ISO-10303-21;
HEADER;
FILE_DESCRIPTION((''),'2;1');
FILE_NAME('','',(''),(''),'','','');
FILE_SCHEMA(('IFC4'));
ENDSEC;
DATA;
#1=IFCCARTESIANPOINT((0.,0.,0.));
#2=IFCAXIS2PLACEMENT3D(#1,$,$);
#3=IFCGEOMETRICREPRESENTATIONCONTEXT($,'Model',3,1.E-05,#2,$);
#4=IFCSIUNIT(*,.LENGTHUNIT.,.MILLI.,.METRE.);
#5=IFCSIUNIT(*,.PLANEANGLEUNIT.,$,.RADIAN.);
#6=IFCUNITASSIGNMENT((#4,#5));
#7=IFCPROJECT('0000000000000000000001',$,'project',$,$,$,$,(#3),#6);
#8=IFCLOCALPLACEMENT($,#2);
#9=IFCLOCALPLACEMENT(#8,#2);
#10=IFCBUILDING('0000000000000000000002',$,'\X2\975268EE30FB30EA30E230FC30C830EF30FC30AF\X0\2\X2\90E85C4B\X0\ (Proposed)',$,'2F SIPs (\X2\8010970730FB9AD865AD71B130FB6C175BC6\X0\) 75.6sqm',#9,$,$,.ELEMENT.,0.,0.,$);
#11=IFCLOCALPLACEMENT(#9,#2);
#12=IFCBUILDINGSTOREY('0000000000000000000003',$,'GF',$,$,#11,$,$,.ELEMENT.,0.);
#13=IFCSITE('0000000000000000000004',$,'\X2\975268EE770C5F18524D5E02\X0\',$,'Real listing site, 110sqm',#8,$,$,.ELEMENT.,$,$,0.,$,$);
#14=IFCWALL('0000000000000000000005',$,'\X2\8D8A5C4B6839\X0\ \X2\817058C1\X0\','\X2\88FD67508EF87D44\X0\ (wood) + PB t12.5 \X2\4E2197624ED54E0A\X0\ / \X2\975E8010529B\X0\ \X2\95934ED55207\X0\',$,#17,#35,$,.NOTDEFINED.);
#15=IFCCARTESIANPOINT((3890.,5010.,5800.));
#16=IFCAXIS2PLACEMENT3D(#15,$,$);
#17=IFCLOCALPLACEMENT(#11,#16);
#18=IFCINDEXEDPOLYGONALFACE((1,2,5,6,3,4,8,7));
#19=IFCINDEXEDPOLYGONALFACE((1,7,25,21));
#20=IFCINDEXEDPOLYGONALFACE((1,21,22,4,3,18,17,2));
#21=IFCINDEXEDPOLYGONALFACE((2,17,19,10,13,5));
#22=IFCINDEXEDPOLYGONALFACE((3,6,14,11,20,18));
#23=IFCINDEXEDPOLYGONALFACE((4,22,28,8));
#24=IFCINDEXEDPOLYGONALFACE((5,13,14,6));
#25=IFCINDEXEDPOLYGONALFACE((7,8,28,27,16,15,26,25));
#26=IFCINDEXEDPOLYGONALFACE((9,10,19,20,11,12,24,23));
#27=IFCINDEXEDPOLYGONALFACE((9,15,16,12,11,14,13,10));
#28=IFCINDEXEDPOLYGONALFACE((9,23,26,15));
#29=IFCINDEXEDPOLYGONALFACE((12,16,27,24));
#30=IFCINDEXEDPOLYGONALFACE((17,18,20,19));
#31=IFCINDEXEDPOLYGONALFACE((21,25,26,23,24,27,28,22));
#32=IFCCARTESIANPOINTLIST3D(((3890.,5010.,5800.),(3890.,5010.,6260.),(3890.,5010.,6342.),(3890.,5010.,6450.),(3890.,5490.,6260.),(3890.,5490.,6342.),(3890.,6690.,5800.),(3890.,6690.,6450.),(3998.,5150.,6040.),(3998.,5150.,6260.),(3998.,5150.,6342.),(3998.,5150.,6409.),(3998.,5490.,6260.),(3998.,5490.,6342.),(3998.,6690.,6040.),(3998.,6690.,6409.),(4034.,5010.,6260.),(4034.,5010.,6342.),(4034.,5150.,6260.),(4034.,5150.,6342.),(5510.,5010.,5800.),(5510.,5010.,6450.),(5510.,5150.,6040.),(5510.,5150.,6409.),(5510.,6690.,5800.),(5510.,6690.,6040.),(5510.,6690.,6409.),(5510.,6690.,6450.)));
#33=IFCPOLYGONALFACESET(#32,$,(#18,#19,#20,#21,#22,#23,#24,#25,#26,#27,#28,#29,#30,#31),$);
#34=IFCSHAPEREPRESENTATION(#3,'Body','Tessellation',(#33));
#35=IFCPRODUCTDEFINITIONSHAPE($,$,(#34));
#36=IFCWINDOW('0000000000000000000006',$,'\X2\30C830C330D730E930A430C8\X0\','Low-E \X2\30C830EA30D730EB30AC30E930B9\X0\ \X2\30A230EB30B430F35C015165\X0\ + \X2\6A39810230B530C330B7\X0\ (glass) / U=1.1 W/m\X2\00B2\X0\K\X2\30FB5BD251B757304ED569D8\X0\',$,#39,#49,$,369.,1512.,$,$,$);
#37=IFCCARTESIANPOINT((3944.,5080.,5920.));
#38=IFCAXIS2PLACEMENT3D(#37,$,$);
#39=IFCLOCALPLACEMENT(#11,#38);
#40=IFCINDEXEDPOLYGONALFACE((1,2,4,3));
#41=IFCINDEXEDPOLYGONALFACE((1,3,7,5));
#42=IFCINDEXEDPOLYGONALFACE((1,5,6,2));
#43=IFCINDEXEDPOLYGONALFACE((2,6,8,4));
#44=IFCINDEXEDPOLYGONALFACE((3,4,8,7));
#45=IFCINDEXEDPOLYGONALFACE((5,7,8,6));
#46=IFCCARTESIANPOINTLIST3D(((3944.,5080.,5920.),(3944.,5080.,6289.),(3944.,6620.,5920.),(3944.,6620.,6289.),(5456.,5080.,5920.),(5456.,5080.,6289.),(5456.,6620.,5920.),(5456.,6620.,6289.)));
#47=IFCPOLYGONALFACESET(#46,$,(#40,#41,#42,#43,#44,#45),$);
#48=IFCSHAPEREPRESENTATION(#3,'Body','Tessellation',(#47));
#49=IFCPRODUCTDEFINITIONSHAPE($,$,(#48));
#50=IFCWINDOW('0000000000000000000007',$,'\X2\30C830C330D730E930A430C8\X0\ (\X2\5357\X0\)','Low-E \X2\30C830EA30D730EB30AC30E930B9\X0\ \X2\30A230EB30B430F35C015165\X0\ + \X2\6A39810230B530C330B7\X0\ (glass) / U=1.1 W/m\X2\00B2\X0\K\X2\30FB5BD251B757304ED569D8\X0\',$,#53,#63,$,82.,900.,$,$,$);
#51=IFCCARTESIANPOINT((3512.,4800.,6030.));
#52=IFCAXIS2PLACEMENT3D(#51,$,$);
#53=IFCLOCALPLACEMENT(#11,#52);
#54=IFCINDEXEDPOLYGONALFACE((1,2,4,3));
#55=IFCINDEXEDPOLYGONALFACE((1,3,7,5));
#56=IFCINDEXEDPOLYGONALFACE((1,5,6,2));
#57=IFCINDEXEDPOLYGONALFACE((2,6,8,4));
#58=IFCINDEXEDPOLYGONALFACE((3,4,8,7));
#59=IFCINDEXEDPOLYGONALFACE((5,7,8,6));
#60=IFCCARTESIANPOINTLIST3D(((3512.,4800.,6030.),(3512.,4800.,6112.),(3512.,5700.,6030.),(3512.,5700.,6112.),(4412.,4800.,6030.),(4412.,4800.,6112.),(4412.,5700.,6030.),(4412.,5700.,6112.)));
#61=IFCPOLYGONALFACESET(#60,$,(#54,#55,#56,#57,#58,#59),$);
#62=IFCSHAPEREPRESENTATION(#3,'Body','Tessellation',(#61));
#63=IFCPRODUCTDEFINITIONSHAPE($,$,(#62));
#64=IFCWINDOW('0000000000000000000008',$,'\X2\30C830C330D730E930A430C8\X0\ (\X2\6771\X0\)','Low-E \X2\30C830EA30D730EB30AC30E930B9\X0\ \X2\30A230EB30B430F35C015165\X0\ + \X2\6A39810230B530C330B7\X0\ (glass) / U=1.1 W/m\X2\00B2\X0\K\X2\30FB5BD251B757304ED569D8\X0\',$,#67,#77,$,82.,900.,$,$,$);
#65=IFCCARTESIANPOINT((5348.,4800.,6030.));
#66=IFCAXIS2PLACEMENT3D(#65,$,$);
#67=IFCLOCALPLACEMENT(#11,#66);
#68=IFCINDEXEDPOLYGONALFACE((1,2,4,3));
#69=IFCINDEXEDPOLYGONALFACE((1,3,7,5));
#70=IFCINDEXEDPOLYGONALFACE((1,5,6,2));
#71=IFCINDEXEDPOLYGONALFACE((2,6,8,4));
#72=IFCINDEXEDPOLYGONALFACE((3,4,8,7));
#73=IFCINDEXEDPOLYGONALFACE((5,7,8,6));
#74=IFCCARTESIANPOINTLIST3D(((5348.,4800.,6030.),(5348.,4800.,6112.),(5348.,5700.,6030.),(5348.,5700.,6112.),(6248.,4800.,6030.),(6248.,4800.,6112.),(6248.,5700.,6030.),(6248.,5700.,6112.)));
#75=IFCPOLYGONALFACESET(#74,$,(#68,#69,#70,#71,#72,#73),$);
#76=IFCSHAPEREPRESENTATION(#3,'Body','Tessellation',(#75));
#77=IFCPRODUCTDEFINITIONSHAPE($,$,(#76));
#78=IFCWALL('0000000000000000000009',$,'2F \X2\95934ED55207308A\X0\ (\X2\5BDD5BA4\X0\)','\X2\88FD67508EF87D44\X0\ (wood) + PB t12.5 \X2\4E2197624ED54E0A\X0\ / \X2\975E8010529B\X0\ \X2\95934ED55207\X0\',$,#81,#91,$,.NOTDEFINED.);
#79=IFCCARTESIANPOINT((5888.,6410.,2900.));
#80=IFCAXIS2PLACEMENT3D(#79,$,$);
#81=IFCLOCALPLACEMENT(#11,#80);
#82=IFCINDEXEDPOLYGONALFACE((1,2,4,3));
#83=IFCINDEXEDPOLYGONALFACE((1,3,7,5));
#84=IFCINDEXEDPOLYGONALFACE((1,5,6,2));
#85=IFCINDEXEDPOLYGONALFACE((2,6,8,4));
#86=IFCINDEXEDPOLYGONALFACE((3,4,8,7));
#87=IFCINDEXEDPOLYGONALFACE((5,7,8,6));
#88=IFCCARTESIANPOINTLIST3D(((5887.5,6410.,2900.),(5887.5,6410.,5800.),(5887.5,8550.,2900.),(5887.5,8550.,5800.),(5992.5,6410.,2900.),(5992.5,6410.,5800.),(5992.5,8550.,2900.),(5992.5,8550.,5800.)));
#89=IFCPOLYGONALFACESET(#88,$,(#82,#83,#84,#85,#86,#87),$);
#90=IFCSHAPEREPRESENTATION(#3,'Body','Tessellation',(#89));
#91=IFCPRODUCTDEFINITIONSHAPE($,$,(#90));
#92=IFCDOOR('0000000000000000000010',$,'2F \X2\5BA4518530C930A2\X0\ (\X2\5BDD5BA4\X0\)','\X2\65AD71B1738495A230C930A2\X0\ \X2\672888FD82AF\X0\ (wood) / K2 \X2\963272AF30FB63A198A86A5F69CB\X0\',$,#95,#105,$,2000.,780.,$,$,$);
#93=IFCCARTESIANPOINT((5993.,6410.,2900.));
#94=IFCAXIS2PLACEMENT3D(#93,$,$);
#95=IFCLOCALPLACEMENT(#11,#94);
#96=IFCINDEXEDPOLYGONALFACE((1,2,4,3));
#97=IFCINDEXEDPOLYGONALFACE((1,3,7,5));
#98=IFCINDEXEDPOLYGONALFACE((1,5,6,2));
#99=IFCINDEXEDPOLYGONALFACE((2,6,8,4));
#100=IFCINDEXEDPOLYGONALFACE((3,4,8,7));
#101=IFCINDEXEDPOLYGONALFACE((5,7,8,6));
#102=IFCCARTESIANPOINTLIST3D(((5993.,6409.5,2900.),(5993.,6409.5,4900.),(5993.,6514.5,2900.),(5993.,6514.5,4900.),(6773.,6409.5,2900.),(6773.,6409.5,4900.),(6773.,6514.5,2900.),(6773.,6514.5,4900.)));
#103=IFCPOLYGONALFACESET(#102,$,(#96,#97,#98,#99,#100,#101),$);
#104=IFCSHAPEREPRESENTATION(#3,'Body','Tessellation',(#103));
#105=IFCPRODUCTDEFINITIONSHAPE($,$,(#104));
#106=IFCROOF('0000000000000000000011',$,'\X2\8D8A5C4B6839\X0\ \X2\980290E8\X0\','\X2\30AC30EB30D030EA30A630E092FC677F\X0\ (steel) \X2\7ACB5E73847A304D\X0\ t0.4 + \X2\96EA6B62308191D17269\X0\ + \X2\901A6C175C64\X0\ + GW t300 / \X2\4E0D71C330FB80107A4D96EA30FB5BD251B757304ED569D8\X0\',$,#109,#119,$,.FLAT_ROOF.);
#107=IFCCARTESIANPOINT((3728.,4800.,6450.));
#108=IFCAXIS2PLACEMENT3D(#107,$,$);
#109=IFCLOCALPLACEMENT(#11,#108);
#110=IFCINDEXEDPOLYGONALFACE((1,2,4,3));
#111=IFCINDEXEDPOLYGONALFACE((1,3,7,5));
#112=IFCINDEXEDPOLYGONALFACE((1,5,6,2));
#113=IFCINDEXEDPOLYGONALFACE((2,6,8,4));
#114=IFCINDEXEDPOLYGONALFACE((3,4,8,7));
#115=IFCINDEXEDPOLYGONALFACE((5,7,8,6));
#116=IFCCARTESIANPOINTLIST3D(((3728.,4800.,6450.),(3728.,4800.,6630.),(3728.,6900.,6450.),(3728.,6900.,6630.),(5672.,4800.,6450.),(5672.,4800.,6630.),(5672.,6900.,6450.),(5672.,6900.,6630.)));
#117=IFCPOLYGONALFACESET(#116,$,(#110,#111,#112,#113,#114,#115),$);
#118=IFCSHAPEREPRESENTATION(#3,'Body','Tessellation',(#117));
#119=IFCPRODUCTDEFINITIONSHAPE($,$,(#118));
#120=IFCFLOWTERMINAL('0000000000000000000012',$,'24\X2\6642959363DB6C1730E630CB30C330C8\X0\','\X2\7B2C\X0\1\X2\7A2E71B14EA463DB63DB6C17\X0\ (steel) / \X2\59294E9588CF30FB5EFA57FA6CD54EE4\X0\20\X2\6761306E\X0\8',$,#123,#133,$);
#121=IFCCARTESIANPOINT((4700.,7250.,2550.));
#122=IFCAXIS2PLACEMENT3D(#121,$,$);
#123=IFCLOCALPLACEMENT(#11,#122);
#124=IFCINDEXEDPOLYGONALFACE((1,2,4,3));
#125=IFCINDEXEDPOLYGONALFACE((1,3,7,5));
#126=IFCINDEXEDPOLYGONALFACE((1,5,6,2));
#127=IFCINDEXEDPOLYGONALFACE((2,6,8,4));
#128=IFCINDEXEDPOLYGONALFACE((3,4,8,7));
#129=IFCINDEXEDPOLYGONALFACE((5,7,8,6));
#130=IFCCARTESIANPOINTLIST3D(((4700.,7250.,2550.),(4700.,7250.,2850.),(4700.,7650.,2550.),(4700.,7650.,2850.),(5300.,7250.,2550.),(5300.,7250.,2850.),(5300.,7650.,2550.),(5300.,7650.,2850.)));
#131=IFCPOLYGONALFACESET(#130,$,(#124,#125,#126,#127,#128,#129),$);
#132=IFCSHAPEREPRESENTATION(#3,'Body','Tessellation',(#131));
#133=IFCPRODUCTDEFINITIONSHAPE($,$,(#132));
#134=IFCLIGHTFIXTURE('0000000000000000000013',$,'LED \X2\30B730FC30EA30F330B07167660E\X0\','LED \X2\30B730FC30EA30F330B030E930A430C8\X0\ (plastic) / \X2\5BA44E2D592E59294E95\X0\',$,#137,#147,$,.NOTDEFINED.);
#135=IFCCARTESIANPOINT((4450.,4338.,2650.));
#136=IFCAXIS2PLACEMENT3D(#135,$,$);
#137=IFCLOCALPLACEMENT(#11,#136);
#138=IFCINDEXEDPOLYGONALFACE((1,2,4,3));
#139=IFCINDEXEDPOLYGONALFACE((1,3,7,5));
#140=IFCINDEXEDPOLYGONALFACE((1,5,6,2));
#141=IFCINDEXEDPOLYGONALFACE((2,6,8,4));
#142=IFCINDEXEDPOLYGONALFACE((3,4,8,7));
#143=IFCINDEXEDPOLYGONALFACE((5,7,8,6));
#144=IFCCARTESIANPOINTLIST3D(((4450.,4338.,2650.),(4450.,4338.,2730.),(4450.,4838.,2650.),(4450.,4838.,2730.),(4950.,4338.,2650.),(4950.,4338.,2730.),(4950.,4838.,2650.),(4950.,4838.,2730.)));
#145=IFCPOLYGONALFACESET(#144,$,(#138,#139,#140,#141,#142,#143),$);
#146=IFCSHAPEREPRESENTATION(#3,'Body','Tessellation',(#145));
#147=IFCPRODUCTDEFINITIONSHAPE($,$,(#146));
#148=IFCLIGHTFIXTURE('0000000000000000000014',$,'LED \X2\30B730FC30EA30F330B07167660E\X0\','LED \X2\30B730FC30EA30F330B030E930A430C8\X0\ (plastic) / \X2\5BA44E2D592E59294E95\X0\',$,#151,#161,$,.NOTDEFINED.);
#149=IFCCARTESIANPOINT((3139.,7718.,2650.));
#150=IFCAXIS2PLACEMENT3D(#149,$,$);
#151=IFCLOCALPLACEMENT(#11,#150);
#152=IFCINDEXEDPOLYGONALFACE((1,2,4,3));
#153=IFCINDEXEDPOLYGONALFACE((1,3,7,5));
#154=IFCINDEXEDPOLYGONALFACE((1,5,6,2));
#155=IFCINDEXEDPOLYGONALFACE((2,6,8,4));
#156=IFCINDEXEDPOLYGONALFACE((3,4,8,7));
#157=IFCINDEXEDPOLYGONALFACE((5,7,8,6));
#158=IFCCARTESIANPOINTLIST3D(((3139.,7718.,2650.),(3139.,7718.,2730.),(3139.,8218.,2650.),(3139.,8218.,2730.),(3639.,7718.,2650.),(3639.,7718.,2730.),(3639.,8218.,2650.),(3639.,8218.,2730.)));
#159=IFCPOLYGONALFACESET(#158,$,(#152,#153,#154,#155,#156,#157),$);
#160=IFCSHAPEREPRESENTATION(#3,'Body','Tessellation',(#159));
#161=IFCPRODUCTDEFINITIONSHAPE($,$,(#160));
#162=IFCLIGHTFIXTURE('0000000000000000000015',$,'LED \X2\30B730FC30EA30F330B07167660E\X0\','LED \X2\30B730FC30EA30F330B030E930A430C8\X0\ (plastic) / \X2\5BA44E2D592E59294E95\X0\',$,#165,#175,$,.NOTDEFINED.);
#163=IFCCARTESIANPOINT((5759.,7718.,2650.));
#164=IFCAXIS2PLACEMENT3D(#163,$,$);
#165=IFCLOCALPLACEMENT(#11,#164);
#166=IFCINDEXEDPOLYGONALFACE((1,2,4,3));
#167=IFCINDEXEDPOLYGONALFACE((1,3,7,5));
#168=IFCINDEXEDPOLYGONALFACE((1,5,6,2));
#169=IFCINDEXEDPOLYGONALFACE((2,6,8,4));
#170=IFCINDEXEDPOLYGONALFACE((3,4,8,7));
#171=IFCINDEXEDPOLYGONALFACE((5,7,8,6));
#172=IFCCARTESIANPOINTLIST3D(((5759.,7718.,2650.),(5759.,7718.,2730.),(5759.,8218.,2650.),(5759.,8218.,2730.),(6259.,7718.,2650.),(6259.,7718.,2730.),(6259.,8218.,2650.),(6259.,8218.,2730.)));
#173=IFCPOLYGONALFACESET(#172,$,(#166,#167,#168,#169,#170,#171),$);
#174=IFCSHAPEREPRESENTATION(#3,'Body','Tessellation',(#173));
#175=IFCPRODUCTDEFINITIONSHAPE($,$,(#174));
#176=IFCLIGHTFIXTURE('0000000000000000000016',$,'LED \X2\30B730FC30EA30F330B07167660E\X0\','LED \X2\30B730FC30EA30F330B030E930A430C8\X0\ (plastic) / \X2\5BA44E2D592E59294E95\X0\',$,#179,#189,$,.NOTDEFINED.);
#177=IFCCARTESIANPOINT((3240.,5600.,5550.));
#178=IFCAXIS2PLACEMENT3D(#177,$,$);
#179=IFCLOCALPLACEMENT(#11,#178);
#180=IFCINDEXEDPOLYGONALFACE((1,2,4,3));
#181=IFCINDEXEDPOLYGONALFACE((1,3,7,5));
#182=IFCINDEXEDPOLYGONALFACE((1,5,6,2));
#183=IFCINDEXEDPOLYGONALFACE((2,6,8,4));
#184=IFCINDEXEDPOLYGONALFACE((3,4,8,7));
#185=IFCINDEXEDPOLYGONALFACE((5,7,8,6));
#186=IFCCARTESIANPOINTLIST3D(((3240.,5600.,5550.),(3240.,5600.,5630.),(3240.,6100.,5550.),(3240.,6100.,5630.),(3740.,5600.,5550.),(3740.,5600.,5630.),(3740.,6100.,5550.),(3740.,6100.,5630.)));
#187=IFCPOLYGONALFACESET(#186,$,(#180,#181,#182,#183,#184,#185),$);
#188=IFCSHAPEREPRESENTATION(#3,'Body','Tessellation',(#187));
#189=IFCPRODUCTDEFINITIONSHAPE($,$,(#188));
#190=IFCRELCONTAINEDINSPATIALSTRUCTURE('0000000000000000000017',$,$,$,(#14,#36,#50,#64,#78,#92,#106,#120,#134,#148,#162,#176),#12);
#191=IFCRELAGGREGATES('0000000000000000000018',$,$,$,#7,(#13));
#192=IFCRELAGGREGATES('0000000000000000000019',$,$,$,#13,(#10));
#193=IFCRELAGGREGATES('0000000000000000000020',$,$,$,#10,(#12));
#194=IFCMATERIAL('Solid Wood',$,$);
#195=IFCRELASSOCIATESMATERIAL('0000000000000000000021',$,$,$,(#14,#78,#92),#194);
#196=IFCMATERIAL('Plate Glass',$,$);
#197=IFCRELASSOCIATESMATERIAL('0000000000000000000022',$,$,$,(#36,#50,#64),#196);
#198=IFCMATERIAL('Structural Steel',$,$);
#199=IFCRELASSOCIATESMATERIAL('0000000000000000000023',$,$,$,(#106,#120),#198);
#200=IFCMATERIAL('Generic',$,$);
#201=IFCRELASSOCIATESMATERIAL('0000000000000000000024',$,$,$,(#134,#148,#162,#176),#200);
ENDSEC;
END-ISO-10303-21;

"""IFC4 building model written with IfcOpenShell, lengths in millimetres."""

from ifc_helpers import new_model, si_unit, frame, frame_2d, origin, place, context, project, spatial, rectangle, extrude, material, element, fill, save


model = new_model("IFC4")

# Units and contexts
model_context = context("Model", 3, precision=1e-05, world=origin())
ifc_project = project(units=[si_unit("LENGTHUNIT", "METRE", prefix="MILLI"), si_unit("PLANEANGLEUNIT", "RADIAN")], contexts=[model_context])

# Site, building, storey
site_placement = place(None, origin())
site = spatial("IfcSite", under=ifc_project, at=site_placement, Name="青森県弘前市", ObjectType="Real listing site, 110sqm", CompositionType="ELEMENT", RefElevation=0.0)
building_placement = place(site_placement, origin())
building = spatial("IfcBuilding", under=site, at=building_placement, Name="青森・リモートワーク2部屋 (Proposed)", ObjectType="2F SIPs (耐震・高断熱・気密) 75.6sqm", CompositionType="ELEMENT", ElevationOfRefHeight=0.0, ElevationOfTerrain=0.0)
storey_placement = place(building_placement, origin())
storey = spatial("IfcBuildingStorey", under=building, at=storey_placement, Name="GF", CompositionType="ELEMENT", Elevation=0.0)

# Shared definitions
ifc_material_1 = material(Name="Solid Wood")

# Shared definitions
ifc_material_2 = material(Name="Plate Glass")

# Wall, openings, windows
wall_1_placement = place(storey_placement, frame((3890.0, 5010.0, 5800.0)))
wall_1 = element("IfcWall", 1, at=wall_1_placement, inside=storey, material=ifc_material_1, Name="越屋根 腰壁", Description="製材軸組 (wood) + PB t12.5 両面仕上 / 非耐力 間仕切", PredefinedType="NOTDEFINED", context=model_context, shape_type="SweptSolid", body=[
    extrude(rectangle(XDim=1620.0, YDim=1680.0, at=frame_2d((810.0, 840.0))), frame((3890.0, 5010.0, 5800.0)), (0.0, 0.0, 1.0), 650.0),
])
opening_1_placement = place(storey_placement, frame((3944.0, 5080.0, 5920.0)))
opening_1 = element("IfcOpeningElement", 2, at=opening_1_placement, cuts=wall_1, PredefinedType="NOTDEFINED", context=model_context, shape_type="SweptSolid", body=[
    extrude(rectangle(XDim=1512.0, YDim=1540.0, at=frame_2d((756.0, 770.0))), frame((3944.0, 5080.0, 5920.0)), (0.0, 0.0, 1.0), 369.0),
])
opening_2_placement = place(storey_placement, frame((3512.0, 4800.0, 6030.0)))
opening_2 = element("IfcOpeningElement", 3, at=opening_2_placement, cuts=wall_1, PredefinedType="NOTDEFINED", context=model_context, shape_type="SweptSolid", body=[
    extrude(rectangle(XDim=900.0, YDim=900.0, at=frame_2d((450.0, 450.0))), frame((3512.0, 4800.0, 6030.0)), (0.0, 0.0, 1.0), 82.0),
])
opening_3_placement = place(storey_placement, frame((5348.0, 4800.0, 6030.0)))
opening_3 = element("IfcOpeningElement", 4, at=opening_3_placement, cuts=wall_1, PredefinedType="NOTDEFINED", context=model_context, shape_type="SweptSolid", body=[
    extrude(rectangle(XDim=900.0, YDim=900.0, at=frame_2d((450.0, 450.0))), frame((5348.0, 4800.0, 6030.0)), (0.0, 0.0, 1.0), 82.0),
])
window_1_placement = place(storey_placement, frame((3944.0, 5080.0, 5920.0)))
window_1 = element("IfcWindow", 5, at=window_1_placement, inside=storey, material=ifc_material_2, Name="トップライト", Description="Low-E トリプルガラス アルゴン封入 + 樹脂サッシ (glass) / U=1.1 W/m²K・寒冷地仕様", OverallHeight=369.0, OverallWidth=1512.0, context=model_context, shape_type="SweptSolid", body=[
    extrude(rectangle(XDim=1512.0, YDim=1540.0, at=frame_2d((756.0, 770.0))), frame((3944.0, 5080.0, 5920.0)), (0.0, 0.0, 1.0), 369.0),
])
fill(opening_1, window_1)
window_2_placement = place(storey_placement, frame((3512.0, 4800.0, 6030.0)))
window_2 = element("IfcWindow", 6, at=window_2_placement, inside=storey, material=ifc_material_2, Name="トップライト (南)", Description="Low-E トリプルガラス アルゴン封入 + 樹脂サッシ (glass) / U=1.1 W/m²K・寒冷地仕様", OverallHeight=82.0, OverallWidth=900.0, context=model_context, shape_type="SweptSolid", body=[
    extrude(rectangle(XDim=900.0, YDim=900.0, at=frame_2d((450.0, 450.0))), frame((3512.0, 4800.0, 6030.0)), (0.0, 0.0, 1.0), 82.0),
])
fill(opening_2, window_2)
window_3_placement = place(storey_placement, frame((5348.0, 4800.0, 6030.0)))
window_3 = element("IfcWindow", 7, at=window_3_placement, inside=storey, material=ifc_material_2, Name="トップライト (東)", Description="Low-E トリプルガラス アルゴン封入 + 樹脂サッシ (glass) / U=1.1 W/m²K・寒冷地仕様", OverallHeight=82.0, OverallWidth=900.0, context=model_context, shape_type="SweptSolid", body=[
    extrude(rectangle(XDim=900.0, YDim=900.0, at=frame_2d((450.0, 450.0))), frame((5348.0, 4800.0, 6030.0)), (0.0, 0.0, 1.0), 82.0),
])
fill(opening_3, window_3)

# Wall
wall_2_placement = place(storey_placement, frame((5888.0, 6410.0, 2900.0)))
element("IfcWall", 8, at=wall_2_placement, inside=storey, material=ifc_material_1, Name="2F 間仕切り (寝室)", Description="製材軸組 (wood) + PB t12.5 両面仕上 / 非耐力 間仕切", PredefinedType="NOTDEFINED", context=model_context, shape_type="SweptSolid", body=[
    extrude(rectangle(XDim=105.0, YDim=2140.0, at=frame_2d((52.0, 1070.0))), frame((5888.0, 6410.0, 2900.0)), (0.0, 0.0, 1.0), 2900.0),
])

# Door
door_placement = place(storey_placement, frame((5993.0, 6410.0, 2900.0)))
element("IfcDoor", 9, at=door_placement, inside=storey, material=ifc_material_1, Name="2F 室内ドア (寝室)", Description="断熱玄関ドア 木製芯 (wood) / K2 防犯・採風機構", OverallHeight=2000.0, OverallWidth=780.0, context=model_context, shape_type="SweptSolid", body=[
    extrude(rectangle(XDim=780.0, YDim=105.0, at=frame_2d((390.0, 52.0))), frame((5993.0, 6410.0, 2900.0)), (0.0, 0.0, 1.0), 2000.0),
])

# Roof
ifc_material_3 = material(Name="Structural Steel")
roof_placement = place(storey_placement, frame((3728.0, 4800.0, 6450.0)))
element("IfcRoof", 10, at=roof_placement, inside=storey, material=ifc_material_3, Name="越屋根 頂部", Description="ガルバリウム鋼板 (steel) 立平葺き t0.4 + 雪止め金物 + 通気層 + GW t300 / 不燃・耐積雪・寒冷地仕様", PredefinedType="FLAT_ROOF", context=model_context, shape_type="SweptSolid", body=[
    extrude(rectangle(XDim=1944.0, YDim=2100.0, at=frame_2d((972.0, 1050.0))), frame((3728.0, 4800.0, 6450.0)), (0.0, 0.0, 1.0), 180.0),
])

# Flow terminal
flow_terminal_placement = place(storey_placement, frame((4700.0, 7250.0, 2550.0)))
element("IfcFlowTerminal", 11, at=flow_terminal_placement, inside=storey, material=ifc_material_3, Name="24時間換気ユニット", Description="第1種熱交換換気 (steel) / 天井裏・建基法令20条の8", context=model_context, shape_type="SweptSolid", body=[
    extrude(rectangle(XDim=600.0, YDim=400.0, at=frame_2d((300.0, 200.0))), frame((4700.0, 7250.0, 2550.0)), (0.0, 0.0, 1.0), 300.0),
])

# Light fixtures
ifc_material_4 = material(Name="Generic")
light_fixture_1_placement = place(storey_placement, frame((4450.0, 4338.0, 2650.0)))
element("IfcLightFixture", 12, at=light_fixture_1_placement, inside=storey, material=ifc_material_4, Name="LED シーリング照明", Description="LED シーリングライト (plastic) / 室中央天井", PredefinedType="NOTDEFINED", context=model_context, shape_type="SweptSolid", body=[
    extrude(rectangle(XDim=500.0, YDim=500.0, at=frame_2d((250.0, 250.0))), frame((4450.0, 4338.0, 2650.0)), (0.0, 0.0, 1.0), 80.0),
])
light_fixture_2_placement = place(storey_placement, frame((3139.0, 7718.0, 2650.0)))
element("IfcLightFixture", 13, at=light_fixture_2_placement, inside=storey, material=ifc_material_4, Name="LED シーリング照明", Description="LED シーリングライト (plastic) / 室中央天井", PredefinedType="NOTDEFINED", context=model_context, shape_type="SweptSolid", body=[
    extrude(rectangle(XDim=500.0, YDim=500.0, at=frame_2d((250.0, 250.0))), frame((3139.0, 7718.0, 2650.0)), (0.0, 0.0, 1.0), 80.0),
])
light_fixture_3_placement = place(storey_placement, frame((5759.0, 7718.0, 2650.0)))
element("IfcLightFixture", 14, at=light_fixture_3_placement, inside=storey, material=ifc_material_4, Name="LED シーリング照明", Description="LED シーリングライト (plastic) / 室中央天井", PredefinedType="NOTDEFINED", context=model_context, shape_type="SweptSolid", body=[
    extrude(rectangle(XDim=500.0, YDim=500.0, at=frame_2d((250.0, 250.0))), frame((5759.0, 7718.0, 2650.0)), (0.0, 0.0, 1.0), 80.0),
])
light_fixture_4_placement = place(storey_placement, frame((3240.0, 5600.0, 5550.0)))
element("IfcLightFixture", 15, at=light_fixture_4_placement, inside=storey, material=ifc_material_4, Name="LED シーリング照明", Description="LED シーリングライト (plastic) / 室中央天井", PredefinedType="NOTDEFINED", context=model_context, shape_type="SweptSolid", body=[
    extrude(rectangle(XDim=500.0, YDim=500.0, at=frame_2d((250.0, 250.0))), frame((3240.0, 5600.0, 5550.0)), (0.0, 0.0, 1.0), 80.0),
])

save(model, "model.ifc")
